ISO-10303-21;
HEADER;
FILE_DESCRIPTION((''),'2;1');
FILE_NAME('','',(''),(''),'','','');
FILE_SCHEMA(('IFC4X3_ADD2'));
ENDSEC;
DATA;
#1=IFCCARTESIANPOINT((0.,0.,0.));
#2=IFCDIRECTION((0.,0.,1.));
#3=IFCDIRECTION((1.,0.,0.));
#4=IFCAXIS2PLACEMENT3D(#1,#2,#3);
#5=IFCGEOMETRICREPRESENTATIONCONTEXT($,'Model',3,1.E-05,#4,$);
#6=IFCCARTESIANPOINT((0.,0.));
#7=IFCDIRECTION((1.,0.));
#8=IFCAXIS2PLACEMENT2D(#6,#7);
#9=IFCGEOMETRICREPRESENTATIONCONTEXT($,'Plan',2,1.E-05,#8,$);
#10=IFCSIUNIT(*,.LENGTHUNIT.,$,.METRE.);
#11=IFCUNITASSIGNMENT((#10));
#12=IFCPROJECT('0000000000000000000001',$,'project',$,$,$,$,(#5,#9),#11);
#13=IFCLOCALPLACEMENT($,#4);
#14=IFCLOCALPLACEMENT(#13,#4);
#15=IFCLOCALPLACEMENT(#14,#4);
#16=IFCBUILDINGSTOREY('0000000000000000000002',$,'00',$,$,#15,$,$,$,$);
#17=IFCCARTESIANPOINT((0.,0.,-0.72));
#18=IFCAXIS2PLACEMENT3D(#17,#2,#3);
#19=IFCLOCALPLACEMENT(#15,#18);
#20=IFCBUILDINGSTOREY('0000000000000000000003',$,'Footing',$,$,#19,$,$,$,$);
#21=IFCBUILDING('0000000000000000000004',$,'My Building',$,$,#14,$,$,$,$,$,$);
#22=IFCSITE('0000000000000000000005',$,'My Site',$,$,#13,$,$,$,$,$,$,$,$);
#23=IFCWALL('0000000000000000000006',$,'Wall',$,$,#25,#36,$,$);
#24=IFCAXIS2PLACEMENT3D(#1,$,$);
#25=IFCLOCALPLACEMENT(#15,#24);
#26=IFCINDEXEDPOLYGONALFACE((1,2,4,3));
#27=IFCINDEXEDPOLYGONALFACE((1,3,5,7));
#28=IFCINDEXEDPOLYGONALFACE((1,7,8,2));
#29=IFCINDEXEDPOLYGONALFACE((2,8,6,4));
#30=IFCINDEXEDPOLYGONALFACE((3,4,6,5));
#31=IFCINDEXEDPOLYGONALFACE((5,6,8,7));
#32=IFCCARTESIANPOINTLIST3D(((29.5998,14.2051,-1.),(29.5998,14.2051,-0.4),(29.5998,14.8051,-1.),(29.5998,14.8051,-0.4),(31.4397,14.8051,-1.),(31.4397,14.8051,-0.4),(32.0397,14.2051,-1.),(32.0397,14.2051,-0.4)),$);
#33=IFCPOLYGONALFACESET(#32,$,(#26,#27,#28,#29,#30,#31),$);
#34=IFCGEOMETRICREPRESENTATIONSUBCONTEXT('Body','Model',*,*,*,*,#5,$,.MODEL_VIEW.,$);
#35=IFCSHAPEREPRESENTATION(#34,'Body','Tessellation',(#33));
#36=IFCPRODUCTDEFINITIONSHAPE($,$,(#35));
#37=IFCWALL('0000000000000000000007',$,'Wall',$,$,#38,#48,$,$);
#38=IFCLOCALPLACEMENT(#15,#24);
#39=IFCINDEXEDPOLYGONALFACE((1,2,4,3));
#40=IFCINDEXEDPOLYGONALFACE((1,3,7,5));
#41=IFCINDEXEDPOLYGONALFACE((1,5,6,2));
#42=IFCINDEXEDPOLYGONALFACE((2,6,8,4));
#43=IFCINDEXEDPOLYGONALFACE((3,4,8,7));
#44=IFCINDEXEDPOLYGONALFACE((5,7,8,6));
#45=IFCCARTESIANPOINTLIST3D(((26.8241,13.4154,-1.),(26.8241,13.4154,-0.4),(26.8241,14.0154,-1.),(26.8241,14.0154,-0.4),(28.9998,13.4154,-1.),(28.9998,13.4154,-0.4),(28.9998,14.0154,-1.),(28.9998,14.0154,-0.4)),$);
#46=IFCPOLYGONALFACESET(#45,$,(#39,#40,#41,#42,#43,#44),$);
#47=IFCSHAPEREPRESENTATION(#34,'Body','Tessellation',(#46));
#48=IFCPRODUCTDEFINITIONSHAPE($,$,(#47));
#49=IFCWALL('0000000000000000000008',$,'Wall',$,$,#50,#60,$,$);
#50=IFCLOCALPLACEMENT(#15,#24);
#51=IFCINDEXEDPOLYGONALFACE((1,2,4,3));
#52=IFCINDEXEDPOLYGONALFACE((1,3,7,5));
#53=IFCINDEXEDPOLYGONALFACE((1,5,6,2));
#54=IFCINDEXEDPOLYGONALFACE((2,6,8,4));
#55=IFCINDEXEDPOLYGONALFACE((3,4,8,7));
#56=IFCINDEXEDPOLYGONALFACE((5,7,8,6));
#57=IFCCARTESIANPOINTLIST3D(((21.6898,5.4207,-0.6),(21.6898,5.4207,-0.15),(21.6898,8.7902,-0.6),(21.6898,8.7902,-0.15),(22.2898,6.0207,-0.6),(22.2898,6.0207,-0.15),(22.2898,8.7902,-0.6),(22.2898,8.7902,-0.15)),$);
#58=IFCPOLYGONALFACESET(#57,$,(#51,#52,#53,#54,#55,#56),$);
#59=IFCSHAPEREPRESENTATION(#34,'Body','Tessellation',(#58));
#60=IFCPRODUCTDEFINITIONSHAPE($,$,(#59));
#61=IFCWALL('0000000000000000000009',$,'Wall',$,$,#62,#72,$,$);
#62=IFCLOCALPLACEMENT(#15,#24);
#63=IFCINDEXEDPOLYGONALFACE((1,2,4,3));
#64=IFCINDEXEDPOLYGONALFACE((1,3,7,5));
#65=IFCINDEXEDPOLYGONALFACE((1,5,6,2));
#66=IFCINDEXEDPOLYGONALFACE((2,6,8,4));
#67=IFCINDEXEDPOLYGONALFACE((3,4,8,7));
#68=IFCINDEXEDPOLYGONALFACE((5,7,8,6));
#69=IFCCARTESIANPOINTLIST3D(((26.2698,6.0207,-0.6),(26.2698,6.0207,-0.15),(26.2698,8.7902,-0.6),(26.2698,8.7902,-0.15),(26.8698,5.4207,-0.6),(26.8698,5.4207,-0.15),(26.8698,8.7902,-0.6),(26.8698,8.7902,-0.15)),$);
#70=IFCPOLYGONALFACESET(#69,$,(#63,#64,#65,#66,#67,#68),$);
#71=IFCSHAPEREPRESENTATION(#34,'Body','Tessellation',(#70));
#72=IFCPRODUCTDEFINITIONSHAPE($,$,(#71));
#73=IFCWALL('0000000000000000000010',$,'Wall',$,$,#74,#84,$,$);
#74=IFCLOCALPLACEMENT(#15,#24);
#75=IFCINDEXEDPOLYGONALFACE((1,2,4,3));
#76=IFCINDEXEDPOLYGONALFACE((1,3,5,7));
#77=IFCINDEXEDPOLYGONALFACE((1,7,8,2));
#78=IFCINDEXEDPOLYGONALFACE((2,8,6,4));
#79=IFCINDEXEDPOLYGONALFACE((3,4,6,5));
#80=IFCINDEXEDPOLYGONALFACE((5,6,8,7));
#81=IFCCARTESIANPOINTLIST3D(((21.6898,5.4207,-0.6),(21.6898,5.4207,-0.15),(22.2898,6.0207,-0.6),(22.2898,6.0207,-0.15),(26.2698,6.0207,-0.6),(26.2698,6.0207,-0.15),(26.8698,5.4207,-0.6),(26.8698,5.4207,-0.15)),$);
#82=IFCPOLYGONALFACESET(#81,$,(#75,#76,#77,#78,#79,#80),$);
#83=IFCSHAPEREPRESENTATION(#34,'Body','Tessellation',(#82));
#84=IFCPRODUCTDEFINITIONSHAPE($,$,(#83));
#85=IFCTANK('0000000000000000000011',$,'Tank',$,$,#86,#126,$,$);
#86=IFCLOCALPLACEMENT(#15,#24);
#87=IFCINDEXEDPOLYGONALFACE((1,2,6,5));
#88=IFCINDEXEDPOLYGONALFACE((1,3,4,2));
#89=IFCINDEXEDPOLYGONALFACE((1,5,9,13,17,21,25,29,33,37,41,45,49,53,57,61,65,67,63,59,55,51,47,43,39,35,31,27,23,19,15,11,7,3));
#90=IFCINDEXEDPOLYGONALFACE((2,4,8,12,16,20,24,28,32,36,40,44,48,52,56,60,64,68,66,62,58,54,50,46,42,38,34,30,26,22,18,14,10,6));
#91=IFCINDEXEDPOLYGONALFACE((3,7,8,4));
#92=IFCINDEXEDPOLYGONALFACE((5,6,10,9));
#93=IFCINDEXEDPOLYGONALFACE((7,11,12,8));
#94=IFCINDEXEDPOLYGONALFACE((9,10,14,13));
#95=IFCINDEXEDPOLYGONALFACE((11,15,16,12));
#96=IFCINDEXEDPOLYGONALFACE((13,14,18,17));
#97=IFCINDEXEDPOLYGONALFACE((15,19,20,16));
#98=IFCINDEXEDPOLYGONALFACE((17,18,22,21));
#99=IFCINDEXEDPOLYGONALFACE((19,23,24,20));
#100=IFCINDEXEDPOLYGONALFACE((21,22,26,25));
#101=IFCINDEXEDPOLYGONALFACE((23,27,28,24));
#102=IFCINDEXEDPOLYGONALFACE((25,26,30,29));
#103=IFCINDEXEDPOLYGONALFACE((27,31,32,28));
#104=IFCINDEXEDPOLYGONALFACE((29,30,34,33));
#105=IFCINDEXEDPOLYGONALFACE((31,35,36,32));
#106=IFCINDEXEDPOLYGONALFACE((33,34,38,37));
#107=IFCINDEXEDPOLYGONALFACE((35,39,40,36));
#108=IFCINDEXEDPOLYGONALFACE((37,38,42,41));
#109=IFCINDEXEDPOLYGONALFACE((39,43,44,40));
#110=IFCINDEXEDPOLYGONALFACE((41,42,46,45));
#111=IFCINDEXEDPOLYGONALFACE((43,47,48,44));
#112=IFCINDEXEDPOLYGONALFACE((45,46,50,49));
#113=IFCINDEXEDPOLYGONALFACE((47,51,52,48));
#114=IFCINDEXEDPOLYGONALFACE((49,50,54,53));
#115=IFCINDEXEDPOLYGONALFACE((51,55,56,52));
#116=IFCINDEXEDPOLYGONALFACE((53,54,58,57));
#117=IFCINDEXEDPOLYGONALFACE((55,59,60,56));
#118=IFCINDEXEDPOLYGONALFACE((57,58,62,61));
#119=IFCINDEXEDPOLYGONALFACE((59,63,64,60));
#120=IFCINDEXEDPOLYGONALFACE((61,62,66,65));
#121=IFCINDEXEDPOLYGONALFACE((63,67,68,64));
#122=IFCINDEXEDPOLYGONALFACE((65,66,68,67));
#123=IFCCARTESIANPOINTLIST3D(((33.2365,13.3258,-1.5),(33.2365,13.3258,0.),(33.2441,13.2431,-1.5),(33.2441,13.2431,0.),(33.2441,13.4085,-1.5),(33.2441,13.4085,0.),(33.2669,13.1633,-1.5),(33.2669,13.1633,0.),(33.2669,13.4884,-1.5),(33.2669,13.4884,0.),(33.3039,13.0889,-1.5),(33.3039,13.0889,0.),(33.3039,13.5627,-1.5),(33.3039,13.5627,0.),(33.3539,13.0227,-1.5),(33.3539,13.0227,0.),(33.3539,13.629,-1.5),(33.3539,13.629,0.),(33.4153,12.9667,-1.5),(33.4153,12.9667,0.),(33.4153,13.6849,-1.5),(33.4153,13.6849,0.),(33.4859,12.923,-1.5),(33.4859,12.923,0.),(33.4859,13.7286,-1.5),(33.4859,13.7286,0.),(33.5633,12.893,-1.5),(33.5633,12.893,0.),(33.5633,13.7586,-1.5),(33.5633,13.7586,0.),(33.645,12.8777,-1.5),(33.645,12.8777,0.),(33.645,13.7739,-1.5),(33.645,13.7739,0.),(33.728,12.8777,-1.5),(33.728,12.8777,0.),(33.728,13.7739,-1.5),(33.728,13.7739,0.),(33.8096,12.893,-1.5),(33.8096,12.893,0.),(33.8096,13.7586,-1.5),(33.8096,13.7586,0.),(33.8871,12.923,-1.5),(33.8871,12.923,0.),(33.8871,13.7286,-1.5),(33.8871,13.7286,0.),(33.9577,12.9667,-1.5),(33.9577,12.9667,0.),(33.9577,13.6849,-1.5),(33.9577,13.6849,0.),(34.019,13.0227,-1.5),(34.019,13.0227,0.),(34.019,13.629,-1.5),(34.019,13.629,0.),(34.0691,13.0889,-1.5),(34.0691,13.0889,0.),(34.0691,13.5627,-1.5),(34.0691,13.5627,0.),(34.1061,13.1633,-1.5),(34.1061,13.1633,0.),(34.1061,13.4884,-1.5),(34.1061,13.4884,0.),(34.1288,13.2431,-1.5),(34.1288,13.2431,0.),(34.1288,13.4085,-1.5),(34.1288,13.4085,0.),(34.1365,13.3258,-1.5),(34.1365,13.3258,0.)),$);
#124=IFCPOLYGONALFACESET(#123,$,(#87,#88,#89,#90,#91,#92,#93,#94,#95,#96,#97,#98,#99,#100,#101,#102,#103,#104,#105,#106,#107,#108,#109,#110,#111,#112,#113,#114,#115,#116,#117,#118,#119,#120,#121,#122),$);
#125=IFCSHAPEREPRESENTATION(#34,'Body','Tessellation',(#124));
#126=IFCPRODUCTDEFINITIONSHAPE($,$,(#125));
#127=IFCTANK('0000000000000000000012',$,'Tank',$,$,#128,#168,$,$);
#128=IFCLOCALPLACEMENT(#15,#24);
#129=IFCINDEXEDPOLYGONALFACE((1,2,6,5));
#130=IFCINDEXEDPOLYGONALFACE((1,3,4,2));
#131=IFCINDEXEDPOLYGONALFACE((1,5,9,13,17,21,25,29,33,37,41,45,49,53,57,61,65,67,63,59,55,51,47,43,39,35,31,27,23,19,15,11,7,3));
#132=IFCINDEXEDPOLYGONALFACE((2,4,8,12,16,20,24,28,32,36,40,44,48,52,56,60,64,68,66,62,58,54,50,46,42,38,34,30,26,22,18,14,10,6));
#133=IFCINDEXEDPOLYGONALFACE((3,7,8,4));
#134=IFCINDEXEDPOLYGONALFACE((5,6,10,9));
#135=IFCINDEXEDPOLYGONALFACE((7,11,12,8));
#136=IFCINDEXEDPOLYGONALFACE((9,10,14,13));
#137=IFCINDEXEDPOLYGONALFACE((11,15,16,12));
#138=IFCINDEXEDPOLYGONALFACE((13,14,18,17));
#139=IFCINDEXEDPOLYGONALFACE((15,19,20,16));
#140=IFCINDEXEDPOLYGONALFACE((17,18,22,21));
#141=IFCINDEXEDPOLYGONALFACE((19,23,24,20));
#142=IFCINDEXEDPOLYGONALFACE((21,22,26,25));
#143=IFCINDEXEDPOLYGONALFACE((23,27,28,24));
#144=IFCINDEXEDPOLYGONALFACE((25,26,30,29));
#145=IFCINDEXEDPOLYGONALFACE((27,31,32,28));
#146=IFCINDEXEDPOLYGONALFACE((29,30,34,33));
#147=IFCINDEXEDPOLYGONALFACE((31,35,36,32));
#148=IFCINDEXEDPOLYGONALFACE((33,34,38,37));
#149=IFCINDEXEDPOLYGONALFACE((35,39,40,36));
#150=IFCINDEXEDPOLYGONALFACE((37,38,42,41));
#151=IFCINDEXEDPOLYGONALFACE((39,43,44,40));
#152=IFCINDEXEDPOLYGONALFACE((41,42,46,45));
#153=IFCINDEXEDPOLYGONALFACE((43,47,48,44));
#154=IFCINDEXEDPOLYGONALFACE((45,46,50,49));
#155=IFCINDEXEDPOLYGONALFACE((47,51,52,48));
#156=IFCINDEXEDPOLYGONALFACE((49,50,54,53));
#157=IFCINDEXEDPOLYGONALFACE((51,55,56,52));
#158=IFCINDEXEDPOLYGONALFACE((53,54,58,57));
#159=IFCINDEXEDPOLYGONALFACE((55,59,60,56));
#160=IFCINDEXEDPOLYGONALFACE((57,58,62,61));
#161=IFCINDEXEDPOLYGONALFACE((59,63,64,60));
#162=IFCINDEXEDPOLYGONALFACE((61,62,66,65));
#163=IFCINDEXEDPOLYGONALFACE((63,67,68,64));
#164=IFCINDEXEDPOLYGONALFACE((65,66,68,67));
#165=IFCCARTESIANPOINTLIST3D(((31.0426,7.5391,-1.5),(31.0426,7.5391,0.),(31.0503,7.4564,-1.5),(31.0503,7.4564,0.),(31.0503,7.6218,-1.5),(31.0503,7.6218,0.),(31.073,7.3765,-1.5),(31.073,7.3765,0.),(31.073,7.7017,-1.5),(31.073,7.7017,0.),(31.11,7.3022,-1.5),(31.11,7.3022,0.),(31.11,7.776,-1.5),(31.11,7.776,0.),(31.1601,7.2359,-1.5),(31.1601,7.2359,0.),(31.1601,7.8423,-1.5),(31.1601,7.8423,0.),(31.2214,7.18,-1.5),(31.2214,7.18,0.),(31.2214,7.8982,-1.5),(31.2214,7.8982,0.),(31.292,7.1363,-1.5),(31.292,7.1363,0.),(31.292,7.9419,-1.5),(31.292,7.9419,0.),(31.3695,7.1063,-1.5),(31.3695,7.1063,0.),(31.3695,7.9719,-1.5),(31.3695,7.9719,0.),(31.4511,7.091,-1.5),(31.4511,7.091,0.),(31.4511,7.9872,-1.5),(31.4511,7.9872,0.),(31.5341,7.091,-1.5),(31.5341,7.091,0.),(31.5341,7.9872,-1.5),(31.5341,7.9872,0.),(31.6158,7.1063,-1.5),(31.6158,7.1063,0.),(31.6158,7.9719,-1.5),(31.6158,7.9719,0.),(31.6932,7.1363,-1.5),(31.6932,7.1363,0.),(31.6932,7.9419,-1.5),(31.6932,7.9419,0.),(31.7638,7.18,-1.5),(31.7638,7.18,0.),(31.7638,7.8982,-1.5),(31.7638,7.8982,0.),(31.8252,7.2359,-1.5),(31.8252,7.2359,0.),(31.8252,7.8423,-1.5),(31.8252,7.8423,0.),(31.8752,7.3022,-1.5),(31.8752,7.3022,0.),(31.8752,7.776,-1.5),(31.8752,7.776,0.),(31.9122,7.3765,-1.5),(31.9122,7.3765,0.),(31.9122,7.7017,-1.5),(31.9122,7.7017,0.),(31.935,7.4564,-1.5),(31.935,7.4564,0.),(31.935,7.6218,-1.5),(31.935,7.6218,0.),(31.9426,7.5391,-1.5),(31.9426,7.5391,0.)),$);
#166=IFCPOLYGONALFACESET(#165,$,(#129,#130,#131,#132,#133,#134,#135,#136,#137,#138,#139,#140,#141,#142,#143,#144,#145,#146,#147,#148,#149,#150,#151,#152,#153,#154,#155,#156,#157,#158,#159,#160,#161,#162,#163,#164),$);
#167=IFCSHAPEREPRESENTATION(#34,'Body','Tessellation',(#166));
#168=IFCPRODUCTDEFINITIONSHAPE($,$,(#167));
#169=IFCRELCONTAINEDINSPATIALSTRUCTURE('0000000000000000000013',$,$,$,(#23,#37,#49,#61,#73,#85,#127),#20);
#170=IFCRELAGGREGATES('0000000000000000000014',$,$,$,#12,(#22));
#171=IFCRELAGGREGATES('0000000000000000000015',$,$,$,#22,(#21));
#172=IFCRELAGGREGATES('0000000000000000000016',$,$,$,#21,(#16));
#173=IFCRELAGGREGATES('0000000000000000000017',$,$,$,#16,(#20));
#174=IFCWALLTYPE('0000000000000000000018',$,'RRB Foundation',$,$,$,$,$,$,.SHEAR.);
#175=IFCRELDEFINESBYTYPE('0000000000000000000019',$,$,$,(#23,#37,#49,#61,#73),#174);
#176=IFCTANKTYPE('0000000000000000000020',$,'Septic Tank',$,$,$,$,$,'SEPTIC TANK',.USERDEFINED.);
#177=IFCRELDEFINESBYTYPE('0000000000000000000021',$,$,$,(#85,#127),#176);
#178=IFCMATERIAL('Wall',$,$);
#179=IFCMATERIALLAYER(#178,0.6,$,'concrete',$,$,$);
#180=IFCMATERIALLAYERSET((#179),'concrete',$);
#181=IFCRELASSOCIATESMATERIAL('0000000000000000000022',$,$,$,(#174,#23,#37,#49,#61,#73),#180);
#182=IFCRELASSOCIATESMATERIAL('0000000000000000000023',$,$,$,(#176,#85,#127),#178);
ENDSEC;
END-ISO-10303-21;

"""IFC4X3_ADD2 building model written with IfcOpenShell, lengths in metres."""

from ifc_helpers import new_model, si_unit, frame, origin_with_axes, origin_2d_with_axis, place, context, subcontext, project, spatial, line, indexed_curve, circle, outline, extrude, material, layer, layer_set, layer_usage, material_profile, profile_set, profile_usage, type_object, element, save


model = new_model("IFC4X3_ADD2")

# Units and contexts
model_context = context("Model", 3, precision=1e-05, world=origin_with_axes())
plan_context = context("Plan", 2, precision=1e-05, world=origin_2d_with_axis())
body_context = subcontext(model_context, "Body", "Model", "MODEL_VIEW")
ifc_project = project(units=[si_unit("LENGTHUNIT", "METRE")], contexts=[model_context, plan_context])

# Site, building, storeys
site_placement = place(None, origin_with_axes())
site = spatial("IfcSite", under=ifc_project, at=site_placement, Name="My Site")
building_placement = place(site_placement, origin_with_axes())
building = spatial("IfcBuilding", under=site, at=building_placement, Name="My Building")
storey_1_placement = place(building_placement, origin_with_axes())
storey_1 = spatial("IfcBuildingStorey", under=building, at=storey_1_placement, Name="00")
storey_2_placement = place(storey_1_placement, frame((0.0, 0.0, -0.72), z_axis=(0.0, 0.0, 1.0), x_axis=(1.0, 0.0, 0.0)))
storey_2 = spatial("IfcBuildingStorey", under=storey_1, at=storey_2_placement, Name="Footing")

# Shared definitions
ifc_material_1 = material(Name="Wall")

# Walls
ifc_layer_1 = layer(ifc_material_1, 0.6, Name="concrete")
ifc_layer_set_1 = layer_set([ifc_layer_1], Name="concrete")
wall_type_1 = type_object("IfcWallType", Name="RRB Foundation", PredefinedType="SHEAR", material=ifc_layer_set_1)
ifc_layer_usage_1 = layer_usage(ifc_layer_set_1, "AXIS2", "POSITIVE", 0.0)
wall_1_placement = place(storey_2_placement, frame((29.5998, 14.2051, -0.28), z_axis=(0.0, 0.0, 1.0), x_axis=(1.0, 0.0, 0.0)))
element("IfcWall", 1, at=wall_1_placement, inside=storey_2, type_object=wall_type_1, material=ifc_layer_usage_1, Name="Wall", context=body_context, shape_type="SweptSolid", body=[
    extrude(outline(indexed_curve([(0.0, 0.0), (0.0, 0.6), (1.84, 0.6), (2.44, 0.0)], segments=[line(1, 2, 3, 4, 1)])), origin_with_axes(), (0.0, 0.0, 1.0), 0.6),
])
ifc_layer_usage_2 = layer_usage(ifc_layer_set_1, "AXIS2", "POSITIVE", 0.0)
wall_2_placement = place(storey_2_placement, frame((26.8241, 13.4154, -0.28), z_axis=(0.0, 0.0, 1.0), x_axis=(1.0, 0.0, 0.0)))
element("IfcWall", 2, at=wall_2_placement, inside=storey_2, type_object=wall_type_1, material=ifc_layer_usage_2, Name="Wall", context=body_context, shape_type="SweptSolid", body=[
    extrude(outline(indexed_curve([(0.0, 0.0), (0.0, 0.6), (2.1757, 0.6), (2.1757, 0.0)], segments=[line(1, 2, 3, 4, 1)])), origin_with_axes(), (0.0, 0.0, 1.0), 0.6),
])
ifc_layer_usage_3 = layer_usage(ifc_layer_set_1, "AXIS2", "POSITIVE", 0.0)
wall_3_placement = place(storey_2_placement, frame((22.2898, 5.4207, 0.12), z_axis=(0.0, 0.0, 1.0), x_axis=(0.000001, 1.0, 0.0)))
element("IfcWall", 3, at=wall_3_placement, inside=storey_2, type_object=wall_type_1, material=ifc_layer_usage_3, Name="Wall", context=body_context, shape_type="SweptSolid", body=[
    extrude(outline(indexed_curve([(0.6, 0.0), (0.0, 0.6), (3.3695, 0.6), (3.3695, 0.0)], segments=[line(1, 2, 3, 4, 1)])), origin_with_axes(), (0.0, 0.0, 1.0), 0.45),
])
ifc_layer_usage_4 = layer_usage(ifc_layer_set_1, "AXIS2", "POSITIVE", 0.0)
wall_4_placement = place(storey_2_placement, frame((26.8698, 5.4207, 0.12), z_axis=(0.0, 0.0, 1.0), x_axis=(0.000001, 1.0, 0.0)))
element("IfcWall", 4, at=wall_4_placement, inside=storey_2, type_object=wall_type_1, material=ifc_layer_usage_4, Name="Wall", context=body_context, shape_type="SweptSolid", body=[
    extrude(outline(indexed_curve([(0.0, 0.0), (0.6, 0.6), (3.3695, 0.6), (3.3695, 0.0)], segments=[line(1, 2, 3, 4, 1)])), origin_with_axes(), (0.0, 0.0, 1.0), 0.45),
])
ifc_layer_usage_5 = layer_usage(ifc_layer_set_1, "AXIS2", "POSITIVE", 0.0)
wall_5_placement = place(storey_2_placement, frame((22.2898, 5.4207, 0.12), z_axis=(0.0, 0.0, 1.0), x_axis=(1.0, 0.0, 0.0)))
element("IfcWall", 5, at=wall_5_placement, inside=storey_2, type_object=wall_type_1, material=ifc_layer_usage_5, Name="Wall", context=body_context, shape_type="SweptSolid", body=[
    extrude(outline(indexed_curve([(-0.6, 0.0), (0.0, 0.6), (3.98, 0.6), (4.58, 0.0)], segments=[line(1, 2, 3, 4, 1)])), origin_with_axes(), (0.0, 0.0, 1.0), 0.45),
])

# Tanks
ifc_material_profile_1 = material_profile(ifc_material_1, circle(Radius=0.45))
ifc_profile_set_1 = profile_set([ifc_material_profile_1])
ifc_profile_usage_1 = profile_usage(ifc_profile_set_1, cardinal=5)
tank_type = type_object("IfcTankType", Name="Septic Tank", ElementType="SEPTIC TANK", PredefinedType="USERDEFINED", material=ifc_profile_set_1)
tank_1_placement = place(storey_2_placement, frame((33.6865, 13.3258, -0.78), z_axis=(0.0, 0.0, 1.0), x_axis=(-1.0, 0.0, 0.0)))
element("IfcTank", 6, at=tank_1_placement, inside=storey_2, type_object=tank_type, material=ifc_profile_usage_1, Name="Tank", context=body_context, shape_type="SweptSolid", body=[
    extrude(circle(Radius=0.45), origin_with_axes(), (0.0, 0.0, 1.0), 1.5),
])
ifc_profile_usage_2 = profile_usage(ifc_profile_set_1, cardinal=5)
tank_2_placement = place(storey_2_placement, frame((31.4926, 7.5391, -0.78), z_axis=(0.0, 0.0, 1.0), x_axis=(-1.0, 0.0, 0.0)))
element("IfcTank", 7, at=tank_2_placement, inside=storey_2, type_object=tank_type, material=ifc_profile_usage_2, Name="Tank", context=body_context, shape_type="SweptSolid", body=[
    extrude(circle(Radius=0.45), origin_with_axes(), (0.0, 0.0, 1.0), 1.5),
])

save(model, "model.ifc")
